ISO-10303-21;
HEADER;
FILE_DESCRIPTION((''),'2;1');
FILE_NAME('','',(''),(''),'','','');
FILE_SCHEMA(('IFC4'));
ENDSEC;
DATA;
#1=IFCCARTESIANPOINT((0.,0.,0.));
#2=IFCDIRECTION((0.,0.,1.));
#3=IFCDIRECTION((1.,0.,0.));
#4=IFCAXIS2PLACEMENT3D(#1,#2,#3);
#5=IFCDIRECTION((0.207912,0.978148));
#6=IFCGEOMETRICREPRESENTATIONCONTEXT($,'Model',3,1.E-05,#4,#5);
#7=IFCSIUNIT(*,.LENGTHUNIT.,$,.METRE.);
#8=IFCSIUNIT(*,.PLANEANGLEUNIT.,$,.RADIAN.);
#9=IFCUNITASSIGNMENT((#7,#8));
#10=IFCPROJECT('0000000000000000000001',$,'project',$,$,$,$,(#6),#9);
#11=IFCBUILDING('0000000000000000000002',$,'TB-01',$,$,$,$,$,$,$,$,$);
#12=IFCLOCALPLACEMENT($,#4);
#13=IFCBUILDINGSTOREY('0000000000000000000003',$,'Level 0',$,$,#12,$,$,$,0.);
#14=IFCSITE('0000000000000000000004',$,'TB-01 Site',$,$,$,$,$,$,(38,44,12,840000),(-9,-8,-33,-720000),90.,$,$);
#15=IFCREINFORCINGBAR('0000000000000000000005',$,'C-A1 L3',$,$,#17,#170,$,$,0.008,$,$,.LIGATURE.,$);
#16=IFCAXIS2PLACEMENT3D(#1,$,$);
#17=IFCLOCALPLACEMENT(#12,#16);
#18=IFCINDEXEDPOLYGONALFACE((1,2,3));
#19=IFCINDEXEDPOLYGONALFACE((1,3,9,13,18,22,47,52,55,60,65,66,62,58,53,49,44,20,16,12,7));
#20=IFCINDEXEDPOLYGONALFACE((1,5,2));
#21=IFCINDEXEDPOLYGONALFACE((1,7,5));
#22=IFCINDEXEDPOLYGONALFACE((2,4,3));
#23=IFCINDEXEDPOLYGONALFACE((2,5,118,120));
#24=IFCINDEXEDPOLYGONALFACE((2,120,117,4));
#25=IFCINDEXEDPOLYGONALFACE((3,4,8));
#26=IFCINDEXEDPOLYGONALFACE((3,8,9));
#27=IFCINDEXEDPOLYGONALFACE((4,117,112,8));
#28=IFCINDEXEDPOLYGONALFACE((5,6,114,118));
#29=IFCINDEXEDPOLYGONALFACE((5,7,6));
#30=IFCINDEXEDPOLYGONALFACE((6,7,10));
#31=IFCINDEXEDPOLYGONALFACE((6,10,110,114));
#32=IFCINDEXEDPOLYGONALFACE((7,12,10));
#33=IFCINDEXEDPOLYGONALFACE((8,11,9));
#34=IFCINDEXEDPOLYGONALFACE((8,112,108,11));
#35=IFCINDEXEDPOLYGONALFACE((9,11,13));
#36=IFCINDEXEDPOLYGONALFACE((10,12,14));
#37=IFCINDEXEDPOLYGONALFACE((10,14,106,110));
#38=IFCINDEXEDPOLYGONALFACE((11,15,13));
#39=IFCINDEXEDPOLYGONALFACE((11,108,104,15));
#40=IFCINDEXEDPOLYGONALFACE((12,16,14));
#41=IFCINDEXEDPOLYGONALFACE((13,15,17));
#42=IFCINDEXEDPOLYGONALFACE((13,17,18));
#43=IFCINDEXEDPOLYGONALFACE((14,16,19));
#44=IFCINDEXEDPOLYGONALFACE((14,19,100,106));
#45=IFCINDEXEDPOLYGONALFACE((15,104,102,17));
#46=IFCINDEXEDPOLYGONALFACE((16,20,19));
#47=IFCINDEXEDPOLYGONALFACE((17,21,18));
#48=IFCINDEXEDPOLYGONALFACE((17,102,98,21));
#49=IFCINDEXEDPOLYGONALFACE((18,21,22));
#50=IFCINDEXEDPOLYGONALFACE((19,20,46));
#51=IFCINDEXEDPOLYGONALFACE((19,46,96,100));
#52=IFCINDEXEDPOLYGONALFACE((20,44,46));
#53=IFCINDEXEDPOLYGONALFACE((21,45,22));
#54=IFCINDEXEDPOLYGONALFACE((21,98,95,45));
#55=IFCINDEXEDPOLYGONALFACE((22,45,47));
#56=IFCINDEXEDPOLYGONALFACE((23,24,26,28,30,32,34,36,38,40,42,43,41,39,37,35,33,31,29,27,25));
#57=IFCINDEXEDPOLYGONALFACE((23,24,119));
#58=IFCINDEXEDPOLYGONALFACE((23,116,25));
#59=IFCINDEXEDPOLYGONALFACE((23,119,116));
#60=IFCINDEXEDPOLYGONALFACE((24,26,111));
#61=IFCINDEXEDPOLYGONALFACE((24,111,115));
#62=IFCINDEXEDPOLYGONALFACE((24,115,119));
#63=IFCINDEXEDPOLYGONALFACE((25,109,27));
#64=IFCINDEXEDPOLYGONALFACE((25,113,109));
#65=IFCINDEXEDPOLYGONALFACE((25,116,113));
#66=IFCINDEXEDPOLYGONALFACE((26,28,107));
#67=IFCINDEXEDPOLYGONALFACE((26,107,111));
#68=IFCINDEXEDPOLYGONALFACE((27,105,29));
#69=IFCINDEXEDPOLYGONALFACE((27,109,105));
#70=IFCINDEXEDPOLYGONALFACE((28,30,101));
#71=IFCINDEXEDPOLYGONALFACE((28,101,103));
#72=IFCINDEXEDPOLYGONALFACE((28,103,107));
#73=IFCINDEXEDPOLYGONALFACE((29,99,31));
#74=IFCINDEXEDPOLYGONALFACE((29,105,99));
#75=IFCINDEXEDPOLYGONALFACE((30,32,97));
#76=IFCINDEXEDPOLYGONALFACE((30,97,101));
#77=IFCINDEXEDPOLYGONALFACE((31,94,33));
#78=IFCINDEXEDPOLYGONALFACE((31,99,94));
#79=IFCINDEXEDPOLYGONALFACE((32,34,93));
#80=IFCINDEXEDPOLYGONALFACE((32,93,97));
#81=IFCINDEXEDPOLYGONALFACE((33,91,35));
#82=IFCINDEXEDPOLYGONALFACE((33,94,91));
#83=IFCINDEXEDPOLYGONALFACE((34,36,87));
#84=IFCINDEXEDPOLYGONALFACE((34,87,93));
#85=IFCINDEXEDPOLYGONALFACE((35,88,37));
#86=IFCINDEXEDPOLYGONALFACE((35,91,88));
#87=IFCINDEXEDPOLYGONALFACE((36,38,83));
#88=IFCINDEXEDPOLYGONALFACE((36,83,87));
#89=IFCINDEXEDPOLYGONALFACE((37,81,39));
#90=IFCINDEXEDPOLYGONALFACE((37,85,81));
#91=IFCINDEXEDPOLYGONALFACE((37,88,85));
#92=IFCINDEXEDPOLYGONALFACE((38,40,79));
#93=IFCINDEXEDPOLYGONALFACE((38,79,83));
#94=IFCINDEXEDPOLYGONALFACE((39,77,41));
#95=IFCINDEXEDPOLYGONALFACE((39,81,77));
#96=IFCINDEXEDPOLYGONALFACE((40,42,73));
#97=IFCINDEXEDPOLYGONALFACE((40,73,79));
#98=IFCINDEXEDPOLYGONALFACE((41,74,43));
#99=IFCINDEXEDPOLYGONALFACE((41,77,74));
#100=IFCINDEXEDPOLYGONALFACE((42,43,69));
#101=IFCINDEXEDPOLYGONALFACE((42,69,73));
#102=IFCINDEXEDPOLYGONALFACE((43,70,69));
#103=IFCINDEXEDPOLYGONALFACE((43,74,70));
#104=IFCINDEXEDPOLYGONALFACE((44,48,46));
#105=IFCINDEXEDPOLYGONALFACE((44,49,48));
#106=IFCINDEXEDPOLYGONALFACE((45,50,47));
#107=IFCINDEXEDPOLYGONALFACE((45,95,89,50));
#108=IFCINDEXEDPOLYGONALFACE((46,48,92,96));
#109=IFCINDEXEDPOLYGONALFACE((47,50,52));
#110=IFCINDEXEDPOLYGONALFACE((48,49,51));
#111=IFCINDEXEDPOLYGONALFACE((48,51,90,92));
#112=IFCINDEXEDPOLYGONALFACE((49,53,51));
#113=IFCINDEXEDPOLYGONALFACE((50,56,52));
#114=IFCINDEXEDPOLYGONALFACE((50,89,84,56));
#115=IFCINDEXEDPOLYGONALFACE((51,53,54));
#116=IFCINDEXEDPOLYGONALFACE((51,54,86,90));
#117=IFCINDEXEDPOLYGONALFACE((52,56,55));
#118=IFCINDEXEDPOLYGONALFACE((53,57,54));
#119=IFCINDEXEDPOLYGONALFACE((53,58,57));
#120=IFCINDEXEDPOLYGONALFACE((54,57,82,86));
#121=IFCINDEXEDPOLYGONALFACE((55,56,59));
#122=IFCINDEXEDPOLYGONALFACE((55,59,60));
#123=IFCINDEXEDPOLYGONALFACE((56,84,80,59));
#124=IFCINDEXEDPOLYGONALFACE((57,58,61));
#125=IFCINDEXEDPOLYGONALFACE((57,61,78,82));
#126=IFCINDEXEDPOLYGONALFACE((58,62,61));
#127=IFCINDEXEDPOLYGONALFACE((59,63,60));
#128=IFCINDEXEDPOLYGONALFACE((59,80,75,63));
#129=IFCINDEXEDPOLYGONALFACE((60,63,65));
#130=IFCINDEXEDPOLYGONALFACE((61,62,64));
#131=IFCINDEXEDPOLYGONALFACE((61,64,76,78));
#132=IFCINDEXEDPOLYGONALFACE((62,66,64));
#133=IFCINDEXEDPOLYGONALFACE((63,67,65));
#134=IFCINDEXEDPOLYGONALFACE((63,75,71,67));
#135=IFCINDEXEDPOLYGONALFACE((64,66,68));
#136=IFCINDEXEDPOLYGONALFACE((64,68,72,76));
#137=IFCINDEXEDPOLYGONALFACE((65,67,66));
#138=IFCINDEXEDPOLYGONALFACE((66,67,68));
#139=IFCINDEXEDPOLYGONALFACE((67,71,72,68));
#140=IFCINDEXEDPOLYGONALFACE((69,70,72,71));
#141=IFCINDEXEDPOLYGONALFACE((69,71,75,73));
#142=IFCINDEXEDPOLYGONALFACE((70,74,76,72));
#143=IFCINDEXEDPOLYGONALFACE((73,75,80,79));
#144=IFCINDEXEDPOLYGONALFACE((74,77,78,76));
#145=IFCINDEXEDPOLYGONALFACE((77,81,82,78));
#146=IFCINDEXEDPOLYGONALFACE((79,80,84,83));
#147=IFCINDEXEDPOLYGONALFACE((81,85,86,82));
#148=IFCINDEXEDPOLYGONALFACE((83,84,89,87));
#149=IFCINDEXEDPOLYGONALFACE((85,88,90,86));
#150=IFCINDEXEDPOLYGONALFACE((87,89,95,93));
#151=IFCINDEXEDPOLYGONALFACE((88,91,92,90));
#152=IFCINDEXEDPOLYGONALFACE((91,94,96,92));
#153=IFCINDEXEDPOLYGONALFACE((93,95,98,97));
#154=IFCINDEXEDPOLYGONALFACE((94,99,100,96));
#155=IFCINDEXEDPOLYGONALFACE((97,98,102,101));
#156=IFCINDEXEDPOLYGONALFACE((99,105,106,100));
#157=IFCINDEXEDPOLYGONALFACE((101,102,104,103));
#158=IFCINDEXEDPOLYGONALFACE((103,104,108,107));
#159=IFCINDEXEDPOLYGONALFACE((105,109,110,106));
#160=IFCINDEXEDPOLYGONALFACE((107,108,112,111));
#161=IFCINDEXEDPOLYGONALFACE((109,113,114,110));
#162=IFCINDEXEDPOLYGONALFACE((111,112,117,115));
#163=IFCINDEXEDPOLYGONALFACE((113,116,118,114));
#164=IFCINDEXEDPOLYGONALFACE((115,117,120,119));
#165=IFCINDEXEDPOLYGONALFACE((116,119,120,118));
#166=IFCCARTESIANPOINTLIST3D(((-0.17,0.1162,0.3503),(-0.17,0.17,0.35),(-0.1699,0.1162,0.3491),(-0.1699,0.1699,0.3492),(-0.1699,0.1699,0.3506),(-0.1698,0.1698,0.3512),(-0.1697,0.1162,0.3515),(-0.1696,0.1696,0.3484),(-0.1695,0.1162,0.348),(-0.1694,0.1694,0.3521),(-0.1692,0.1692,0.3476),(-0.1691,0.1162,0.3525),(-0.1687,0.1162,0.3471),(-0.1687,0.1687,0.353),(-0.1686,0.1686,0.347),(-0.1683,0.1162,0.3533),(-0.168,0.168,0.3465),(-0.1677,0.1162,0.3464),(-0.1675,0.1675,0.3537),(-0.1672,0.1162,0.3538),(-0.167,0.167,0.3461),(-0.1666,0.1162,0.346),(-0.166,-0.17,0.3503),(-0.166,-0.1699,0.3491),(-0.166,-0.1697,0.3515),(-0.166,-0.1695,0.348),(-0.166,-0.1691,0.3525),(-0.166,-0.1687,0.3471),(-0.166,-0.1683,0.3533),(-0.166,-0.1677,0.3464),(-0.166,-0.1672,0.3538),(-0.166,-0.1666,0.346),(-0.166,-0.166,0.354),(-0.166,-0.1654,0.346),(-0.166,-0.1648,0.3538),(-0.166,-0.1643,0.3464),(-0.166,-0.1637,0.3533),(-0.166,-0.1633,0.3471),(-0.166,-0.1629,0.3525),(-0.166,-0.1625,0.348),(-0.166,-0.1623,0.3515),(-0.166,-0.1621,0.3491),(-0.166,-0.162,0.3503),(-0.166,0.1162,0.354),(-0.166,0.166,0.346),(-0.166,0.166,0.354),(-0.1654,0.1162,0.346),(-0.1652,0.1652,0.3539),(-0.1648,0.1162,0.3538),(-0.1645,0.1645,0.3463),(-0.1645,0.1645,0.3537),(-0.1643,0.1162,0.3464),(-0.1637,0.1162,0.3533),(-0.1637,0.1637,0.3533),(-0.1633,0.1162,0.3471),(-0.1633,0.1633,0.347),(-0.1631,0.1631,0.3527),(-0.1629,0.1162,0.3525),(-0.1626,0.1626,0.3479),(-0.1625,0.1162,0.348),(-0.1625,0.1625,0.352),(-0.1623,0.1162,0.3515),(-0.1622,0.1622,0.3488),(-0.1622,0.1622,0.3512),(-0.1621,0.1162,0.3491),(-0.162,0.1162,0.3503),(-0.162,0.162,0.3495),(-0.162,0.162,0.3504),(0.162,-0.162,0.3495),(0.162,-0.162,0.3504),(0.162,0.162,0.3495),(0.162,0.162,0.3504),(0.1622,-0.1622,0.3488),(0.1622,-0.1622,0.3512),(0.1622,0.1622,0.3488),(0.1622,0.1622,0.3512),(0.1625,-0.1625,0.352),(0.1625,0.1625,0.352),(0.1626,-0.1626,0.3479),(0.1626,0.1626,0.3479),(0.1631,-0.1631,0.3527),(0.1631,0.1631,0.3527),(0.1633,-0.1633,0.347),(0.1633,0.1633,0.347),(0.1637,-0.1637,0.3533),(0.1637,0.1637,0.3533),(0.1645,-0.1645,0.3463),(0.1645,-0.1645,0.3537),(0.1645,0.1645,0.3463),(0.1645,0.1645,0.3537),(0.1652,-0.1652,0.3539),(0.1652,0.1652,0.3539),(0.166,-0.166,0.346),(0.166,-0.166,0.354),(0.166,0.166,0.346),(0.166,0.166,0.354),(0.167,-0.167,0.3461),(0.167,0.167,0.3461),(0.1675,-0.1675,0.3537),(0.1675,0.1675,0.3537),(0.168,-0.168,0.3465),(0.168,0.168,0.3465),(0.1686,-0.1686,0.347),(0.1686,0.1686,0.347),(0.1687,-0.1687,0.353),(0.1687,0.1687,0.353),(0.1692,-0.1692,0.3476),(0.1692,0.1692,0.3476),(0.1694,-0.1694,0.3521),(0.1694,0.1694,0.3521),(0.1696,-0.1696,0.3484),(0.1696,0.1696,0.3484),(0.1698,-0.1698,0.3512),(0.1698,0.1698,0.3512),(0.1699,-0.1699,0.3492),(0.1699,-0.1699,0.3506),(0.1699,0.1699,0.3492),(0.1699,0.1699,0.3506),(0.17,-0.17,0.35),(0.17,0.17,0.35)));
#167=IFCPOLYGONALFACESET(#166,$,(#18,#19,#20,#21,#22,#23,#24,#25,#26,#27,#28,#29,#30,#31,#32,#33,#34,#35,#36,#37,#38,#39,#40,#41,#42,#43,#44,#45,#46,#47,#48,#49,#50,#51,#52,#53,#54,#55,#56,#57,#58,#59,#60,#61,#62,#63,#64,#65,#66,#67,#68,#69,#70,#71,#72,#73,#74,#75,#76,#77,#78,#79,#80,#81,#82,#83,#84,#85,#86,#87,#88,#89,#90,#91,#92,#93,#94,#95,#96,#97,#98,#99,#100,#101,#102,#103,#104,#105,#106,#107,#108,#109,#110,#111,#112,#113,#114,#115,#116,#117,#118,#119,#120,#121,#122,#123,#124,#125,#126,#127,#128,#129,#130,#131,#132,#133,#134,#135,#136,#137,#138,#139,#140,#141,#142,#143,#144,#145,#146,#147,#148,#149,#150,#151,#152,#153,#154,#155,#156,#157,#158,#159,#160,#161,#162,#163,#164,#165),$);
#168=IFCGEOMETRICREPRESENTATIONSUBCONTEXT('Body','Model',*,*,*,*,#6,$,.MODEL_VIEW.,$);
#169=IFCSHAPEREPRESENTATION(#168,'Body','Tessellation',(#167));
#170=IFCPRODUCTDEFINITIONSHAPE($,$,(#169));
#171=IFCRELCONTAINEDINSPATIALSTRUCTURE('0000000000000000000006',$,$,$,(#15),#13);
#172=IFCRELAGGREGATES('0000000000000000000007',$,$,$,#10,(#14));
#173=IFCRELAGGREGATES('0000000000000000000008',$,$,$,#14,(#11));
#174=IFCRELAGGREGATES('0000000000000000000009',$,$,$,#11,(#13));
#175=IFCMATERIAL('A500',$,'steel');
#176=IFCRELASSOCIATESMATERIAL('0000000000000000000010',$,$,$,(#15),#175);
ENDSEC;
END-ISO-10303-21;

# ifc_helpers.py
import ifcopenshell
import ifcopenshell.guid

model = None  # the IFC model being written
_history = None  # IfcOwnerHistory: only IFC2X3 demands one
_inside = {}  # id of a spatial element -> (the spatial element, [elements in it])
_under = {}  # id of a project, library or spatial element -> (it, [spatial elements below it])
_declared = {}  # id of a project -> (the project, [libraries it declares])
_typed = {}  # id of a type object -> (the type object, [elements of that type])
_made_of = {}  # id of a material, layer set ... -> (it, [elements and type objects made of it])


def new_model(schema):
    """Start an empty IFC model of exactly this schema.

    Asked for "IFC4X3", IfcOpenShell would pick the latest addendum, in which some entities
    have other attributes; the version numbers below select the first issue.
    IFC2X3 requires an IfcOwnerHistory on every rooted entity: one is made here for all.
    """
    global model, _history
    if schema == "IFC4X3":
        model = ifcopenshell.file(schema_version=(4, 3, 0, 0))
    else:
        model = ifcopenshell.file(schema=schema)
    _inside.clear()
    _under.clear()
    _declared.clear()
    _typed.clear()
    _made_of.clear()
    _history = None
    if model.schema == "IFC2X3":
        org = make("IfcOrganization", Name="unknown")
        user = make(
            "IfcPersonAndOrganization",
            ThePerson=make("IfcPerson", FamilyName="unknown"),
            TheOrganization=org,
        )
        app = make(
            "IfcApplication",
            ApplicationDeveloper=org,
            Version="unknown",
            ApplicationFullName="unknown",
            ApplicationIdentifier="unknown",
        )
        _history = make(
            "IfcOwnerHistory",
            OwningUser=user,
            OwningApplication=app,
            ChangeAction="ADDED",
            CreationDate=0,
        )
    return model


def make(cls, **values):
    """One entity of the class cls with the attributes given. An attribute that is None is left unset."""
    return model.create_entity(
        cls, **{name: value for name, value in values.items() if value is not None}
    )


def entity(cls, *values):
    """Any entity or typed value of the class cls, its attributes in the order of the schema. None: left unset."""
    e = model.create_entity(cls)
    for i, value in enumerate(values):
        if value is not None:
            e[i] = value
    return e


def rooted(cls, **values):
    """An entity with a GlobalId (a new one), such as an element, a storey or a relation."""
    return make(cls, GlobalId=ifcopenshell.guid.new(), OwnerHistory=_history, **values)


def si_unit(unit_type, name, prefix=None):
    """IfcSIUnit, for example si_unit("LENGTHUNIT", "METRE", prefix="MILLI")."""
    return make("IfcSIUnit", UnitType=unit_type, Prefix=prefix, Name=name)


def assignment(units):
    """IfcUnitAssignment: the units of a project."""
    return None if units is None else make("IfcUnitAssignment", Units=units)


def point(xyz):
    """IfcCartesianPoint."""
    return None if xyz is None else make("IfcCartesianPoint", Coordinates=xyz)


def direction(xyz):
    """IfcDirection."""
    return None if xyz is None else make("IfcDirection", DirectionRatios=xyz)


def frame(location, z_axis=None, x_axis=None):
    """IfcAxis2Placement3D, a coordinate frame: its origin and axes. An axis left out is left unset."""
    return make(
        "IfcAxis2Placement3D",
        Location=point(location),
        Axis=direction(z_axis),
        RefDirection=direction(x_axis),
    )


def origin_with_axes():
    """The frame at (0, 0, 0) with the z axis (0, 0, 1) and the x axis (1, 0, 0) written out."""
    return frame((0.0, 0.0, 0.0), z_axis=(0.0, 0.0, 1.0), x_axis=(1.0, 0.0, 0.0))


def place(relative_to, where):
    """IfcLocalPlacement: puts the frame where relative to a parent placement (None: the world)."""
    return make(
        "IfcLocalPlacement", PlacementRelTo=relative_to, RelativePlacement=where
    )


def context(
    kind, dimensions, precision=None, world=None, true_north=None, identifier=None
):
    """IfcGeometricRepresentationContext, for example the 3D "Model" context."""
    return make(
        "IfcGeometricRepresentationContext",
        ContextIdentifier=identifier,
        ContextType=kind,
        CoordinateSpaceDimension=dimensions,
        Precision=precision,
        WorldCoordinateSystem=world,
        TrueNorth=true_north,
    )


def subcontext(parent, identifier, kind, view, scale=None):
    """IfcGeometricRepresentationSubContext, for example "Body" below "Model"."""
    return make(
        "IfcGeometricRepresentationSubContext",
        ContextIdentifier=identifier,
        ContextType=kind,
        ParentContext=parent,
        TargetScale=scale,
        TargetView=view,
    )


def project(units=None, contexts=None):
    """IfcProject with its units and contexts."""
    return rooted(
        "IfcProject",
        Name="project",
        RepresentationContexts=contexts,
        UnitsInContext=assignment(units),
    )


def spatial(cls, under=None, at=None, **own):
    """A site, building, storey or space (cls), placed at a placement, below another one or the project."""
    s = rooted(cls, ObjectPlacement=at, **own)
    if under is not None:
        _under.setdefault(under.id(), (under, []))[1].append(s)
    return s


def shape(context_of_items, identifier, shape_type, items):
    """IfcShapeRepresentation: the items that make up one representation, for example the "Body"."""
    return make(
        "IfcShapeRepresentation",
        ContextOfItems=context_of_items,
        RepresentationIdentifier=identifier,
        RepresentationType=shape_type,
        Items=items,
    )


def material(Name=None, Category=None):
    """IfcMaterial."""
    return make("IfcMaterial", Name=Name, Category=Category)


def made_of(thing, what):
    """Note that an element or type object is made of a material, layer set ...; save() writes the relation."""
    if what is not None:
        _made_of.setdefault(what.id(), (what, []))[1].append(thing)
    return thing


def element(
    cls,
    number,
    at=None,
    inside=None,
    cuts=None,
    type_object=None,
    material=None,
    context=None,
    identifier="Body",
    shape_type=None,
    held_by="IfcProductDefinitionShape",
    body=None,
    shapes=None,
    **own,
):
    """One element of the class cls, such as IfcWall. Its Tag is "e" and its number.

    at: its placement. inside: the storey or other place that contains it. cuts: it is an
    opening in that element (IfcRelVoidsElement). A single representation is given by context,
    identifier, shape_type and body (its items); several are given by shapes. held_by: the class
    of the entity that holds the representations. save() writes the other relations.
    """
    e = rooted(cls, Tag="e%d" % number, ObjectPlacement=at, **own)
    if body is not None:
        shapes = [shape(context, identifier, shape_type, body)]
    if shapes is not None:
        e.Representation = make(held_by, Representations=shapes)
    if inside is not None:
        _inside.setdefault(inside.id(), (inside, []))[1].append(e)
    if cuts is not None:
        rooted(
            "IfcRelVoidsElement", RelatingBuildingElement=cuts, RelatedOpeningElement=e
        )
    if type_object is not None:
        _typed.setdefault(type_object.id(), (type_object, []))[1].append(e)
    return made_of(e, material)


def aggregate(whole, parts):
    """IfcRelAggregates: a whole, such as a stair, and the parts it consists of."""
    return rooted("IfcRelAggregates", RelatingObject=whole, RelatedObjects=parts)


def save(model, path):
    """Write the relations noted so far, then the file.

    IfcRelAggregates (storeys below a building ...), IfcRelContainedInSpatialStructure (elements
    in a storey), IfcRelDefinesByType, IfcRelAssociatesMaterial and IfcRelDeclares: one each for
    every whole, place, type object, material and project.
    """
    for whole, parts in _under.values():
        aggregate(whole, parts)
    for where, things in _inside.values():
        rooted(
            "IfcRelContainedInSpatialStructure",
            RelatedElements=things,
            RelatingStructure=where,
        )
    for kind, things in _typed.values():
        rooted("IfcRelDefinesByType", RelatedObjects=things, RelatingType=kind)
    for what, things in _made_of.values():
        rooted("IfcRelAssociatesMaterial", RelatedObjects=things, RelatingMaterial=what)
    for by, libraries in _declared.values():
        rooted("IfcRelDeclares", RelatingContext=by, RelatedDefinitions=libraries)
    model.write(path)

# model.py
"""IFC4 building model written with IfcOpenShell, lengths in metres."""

from ifc_helpers import new_model, entity, si_unit, direction, origin_with_axes, place, context, subcontext, project, spatial, material, element, save


model = new_model("IFC4")

# Units and contexts
model_context = context("Model", 3, precision=1e-05, world=origin_with_axes(), true_north=direction((0.207912, 0.978148)))
body_context = subcontext(model_context, "Body", "Model", "MODEL_VIEW")
ifc_project = project(units=[si_unit("LENGTHUNIT", "METRE"), si_unit("PLANEANGLEUNIT", "RADIAN")], contexts=[model_context])

# Site, building, storey
site = spatial("IfcSite", under=ifc_project, Name="TB-01 Site", RefLatitude=(38, 44, 12, 840000), RefLongitude=(-9, -8, -33, -720000), RefElevation=90.0)
building = spatial("IfcBuilding", under=site, Name="TB-01")
storey_placement = place(None, origin_with_axes())
storey = spatial("IfcBuildingStorey", under=building, at=storey_placement, Name="Level 0", Elevation=0.0)

# Reinforcing bar
ifc_material_1 = material(Name="A500", Category="steel")
reinforcing_bar_1_placement = place(storey_placement, origin_with_axes())
element("IfcReinforcingBar", 1, at=reinforcing_bar_1_placement, inside=storey, material=ifc_material_1, Name="C-A1 L3", NominalDiameter=0.008, PredefinedType="LIGATURE", context=body_context, shape_type="AdvancedSweptSolid", body=[
    entity("IfcSweptDiskSolid", entity("IfcPolyline", [entity("IfcCartesianPoint", [-0.166, -0.166, 0.35]), entity("IfcCartesianPoint", [0.166, -0.166, 0.35]), entity("IfcCartesianPoint", [0.166, 0.166, 0.35]), entity("IfcCartesianPoint", [-0.166, 0.166, 0.35]), entity("IfcCartesianPoint", [-0.166, 0.1162, 0.35])]), 0.004),
])

save(model, "model.ifc")
